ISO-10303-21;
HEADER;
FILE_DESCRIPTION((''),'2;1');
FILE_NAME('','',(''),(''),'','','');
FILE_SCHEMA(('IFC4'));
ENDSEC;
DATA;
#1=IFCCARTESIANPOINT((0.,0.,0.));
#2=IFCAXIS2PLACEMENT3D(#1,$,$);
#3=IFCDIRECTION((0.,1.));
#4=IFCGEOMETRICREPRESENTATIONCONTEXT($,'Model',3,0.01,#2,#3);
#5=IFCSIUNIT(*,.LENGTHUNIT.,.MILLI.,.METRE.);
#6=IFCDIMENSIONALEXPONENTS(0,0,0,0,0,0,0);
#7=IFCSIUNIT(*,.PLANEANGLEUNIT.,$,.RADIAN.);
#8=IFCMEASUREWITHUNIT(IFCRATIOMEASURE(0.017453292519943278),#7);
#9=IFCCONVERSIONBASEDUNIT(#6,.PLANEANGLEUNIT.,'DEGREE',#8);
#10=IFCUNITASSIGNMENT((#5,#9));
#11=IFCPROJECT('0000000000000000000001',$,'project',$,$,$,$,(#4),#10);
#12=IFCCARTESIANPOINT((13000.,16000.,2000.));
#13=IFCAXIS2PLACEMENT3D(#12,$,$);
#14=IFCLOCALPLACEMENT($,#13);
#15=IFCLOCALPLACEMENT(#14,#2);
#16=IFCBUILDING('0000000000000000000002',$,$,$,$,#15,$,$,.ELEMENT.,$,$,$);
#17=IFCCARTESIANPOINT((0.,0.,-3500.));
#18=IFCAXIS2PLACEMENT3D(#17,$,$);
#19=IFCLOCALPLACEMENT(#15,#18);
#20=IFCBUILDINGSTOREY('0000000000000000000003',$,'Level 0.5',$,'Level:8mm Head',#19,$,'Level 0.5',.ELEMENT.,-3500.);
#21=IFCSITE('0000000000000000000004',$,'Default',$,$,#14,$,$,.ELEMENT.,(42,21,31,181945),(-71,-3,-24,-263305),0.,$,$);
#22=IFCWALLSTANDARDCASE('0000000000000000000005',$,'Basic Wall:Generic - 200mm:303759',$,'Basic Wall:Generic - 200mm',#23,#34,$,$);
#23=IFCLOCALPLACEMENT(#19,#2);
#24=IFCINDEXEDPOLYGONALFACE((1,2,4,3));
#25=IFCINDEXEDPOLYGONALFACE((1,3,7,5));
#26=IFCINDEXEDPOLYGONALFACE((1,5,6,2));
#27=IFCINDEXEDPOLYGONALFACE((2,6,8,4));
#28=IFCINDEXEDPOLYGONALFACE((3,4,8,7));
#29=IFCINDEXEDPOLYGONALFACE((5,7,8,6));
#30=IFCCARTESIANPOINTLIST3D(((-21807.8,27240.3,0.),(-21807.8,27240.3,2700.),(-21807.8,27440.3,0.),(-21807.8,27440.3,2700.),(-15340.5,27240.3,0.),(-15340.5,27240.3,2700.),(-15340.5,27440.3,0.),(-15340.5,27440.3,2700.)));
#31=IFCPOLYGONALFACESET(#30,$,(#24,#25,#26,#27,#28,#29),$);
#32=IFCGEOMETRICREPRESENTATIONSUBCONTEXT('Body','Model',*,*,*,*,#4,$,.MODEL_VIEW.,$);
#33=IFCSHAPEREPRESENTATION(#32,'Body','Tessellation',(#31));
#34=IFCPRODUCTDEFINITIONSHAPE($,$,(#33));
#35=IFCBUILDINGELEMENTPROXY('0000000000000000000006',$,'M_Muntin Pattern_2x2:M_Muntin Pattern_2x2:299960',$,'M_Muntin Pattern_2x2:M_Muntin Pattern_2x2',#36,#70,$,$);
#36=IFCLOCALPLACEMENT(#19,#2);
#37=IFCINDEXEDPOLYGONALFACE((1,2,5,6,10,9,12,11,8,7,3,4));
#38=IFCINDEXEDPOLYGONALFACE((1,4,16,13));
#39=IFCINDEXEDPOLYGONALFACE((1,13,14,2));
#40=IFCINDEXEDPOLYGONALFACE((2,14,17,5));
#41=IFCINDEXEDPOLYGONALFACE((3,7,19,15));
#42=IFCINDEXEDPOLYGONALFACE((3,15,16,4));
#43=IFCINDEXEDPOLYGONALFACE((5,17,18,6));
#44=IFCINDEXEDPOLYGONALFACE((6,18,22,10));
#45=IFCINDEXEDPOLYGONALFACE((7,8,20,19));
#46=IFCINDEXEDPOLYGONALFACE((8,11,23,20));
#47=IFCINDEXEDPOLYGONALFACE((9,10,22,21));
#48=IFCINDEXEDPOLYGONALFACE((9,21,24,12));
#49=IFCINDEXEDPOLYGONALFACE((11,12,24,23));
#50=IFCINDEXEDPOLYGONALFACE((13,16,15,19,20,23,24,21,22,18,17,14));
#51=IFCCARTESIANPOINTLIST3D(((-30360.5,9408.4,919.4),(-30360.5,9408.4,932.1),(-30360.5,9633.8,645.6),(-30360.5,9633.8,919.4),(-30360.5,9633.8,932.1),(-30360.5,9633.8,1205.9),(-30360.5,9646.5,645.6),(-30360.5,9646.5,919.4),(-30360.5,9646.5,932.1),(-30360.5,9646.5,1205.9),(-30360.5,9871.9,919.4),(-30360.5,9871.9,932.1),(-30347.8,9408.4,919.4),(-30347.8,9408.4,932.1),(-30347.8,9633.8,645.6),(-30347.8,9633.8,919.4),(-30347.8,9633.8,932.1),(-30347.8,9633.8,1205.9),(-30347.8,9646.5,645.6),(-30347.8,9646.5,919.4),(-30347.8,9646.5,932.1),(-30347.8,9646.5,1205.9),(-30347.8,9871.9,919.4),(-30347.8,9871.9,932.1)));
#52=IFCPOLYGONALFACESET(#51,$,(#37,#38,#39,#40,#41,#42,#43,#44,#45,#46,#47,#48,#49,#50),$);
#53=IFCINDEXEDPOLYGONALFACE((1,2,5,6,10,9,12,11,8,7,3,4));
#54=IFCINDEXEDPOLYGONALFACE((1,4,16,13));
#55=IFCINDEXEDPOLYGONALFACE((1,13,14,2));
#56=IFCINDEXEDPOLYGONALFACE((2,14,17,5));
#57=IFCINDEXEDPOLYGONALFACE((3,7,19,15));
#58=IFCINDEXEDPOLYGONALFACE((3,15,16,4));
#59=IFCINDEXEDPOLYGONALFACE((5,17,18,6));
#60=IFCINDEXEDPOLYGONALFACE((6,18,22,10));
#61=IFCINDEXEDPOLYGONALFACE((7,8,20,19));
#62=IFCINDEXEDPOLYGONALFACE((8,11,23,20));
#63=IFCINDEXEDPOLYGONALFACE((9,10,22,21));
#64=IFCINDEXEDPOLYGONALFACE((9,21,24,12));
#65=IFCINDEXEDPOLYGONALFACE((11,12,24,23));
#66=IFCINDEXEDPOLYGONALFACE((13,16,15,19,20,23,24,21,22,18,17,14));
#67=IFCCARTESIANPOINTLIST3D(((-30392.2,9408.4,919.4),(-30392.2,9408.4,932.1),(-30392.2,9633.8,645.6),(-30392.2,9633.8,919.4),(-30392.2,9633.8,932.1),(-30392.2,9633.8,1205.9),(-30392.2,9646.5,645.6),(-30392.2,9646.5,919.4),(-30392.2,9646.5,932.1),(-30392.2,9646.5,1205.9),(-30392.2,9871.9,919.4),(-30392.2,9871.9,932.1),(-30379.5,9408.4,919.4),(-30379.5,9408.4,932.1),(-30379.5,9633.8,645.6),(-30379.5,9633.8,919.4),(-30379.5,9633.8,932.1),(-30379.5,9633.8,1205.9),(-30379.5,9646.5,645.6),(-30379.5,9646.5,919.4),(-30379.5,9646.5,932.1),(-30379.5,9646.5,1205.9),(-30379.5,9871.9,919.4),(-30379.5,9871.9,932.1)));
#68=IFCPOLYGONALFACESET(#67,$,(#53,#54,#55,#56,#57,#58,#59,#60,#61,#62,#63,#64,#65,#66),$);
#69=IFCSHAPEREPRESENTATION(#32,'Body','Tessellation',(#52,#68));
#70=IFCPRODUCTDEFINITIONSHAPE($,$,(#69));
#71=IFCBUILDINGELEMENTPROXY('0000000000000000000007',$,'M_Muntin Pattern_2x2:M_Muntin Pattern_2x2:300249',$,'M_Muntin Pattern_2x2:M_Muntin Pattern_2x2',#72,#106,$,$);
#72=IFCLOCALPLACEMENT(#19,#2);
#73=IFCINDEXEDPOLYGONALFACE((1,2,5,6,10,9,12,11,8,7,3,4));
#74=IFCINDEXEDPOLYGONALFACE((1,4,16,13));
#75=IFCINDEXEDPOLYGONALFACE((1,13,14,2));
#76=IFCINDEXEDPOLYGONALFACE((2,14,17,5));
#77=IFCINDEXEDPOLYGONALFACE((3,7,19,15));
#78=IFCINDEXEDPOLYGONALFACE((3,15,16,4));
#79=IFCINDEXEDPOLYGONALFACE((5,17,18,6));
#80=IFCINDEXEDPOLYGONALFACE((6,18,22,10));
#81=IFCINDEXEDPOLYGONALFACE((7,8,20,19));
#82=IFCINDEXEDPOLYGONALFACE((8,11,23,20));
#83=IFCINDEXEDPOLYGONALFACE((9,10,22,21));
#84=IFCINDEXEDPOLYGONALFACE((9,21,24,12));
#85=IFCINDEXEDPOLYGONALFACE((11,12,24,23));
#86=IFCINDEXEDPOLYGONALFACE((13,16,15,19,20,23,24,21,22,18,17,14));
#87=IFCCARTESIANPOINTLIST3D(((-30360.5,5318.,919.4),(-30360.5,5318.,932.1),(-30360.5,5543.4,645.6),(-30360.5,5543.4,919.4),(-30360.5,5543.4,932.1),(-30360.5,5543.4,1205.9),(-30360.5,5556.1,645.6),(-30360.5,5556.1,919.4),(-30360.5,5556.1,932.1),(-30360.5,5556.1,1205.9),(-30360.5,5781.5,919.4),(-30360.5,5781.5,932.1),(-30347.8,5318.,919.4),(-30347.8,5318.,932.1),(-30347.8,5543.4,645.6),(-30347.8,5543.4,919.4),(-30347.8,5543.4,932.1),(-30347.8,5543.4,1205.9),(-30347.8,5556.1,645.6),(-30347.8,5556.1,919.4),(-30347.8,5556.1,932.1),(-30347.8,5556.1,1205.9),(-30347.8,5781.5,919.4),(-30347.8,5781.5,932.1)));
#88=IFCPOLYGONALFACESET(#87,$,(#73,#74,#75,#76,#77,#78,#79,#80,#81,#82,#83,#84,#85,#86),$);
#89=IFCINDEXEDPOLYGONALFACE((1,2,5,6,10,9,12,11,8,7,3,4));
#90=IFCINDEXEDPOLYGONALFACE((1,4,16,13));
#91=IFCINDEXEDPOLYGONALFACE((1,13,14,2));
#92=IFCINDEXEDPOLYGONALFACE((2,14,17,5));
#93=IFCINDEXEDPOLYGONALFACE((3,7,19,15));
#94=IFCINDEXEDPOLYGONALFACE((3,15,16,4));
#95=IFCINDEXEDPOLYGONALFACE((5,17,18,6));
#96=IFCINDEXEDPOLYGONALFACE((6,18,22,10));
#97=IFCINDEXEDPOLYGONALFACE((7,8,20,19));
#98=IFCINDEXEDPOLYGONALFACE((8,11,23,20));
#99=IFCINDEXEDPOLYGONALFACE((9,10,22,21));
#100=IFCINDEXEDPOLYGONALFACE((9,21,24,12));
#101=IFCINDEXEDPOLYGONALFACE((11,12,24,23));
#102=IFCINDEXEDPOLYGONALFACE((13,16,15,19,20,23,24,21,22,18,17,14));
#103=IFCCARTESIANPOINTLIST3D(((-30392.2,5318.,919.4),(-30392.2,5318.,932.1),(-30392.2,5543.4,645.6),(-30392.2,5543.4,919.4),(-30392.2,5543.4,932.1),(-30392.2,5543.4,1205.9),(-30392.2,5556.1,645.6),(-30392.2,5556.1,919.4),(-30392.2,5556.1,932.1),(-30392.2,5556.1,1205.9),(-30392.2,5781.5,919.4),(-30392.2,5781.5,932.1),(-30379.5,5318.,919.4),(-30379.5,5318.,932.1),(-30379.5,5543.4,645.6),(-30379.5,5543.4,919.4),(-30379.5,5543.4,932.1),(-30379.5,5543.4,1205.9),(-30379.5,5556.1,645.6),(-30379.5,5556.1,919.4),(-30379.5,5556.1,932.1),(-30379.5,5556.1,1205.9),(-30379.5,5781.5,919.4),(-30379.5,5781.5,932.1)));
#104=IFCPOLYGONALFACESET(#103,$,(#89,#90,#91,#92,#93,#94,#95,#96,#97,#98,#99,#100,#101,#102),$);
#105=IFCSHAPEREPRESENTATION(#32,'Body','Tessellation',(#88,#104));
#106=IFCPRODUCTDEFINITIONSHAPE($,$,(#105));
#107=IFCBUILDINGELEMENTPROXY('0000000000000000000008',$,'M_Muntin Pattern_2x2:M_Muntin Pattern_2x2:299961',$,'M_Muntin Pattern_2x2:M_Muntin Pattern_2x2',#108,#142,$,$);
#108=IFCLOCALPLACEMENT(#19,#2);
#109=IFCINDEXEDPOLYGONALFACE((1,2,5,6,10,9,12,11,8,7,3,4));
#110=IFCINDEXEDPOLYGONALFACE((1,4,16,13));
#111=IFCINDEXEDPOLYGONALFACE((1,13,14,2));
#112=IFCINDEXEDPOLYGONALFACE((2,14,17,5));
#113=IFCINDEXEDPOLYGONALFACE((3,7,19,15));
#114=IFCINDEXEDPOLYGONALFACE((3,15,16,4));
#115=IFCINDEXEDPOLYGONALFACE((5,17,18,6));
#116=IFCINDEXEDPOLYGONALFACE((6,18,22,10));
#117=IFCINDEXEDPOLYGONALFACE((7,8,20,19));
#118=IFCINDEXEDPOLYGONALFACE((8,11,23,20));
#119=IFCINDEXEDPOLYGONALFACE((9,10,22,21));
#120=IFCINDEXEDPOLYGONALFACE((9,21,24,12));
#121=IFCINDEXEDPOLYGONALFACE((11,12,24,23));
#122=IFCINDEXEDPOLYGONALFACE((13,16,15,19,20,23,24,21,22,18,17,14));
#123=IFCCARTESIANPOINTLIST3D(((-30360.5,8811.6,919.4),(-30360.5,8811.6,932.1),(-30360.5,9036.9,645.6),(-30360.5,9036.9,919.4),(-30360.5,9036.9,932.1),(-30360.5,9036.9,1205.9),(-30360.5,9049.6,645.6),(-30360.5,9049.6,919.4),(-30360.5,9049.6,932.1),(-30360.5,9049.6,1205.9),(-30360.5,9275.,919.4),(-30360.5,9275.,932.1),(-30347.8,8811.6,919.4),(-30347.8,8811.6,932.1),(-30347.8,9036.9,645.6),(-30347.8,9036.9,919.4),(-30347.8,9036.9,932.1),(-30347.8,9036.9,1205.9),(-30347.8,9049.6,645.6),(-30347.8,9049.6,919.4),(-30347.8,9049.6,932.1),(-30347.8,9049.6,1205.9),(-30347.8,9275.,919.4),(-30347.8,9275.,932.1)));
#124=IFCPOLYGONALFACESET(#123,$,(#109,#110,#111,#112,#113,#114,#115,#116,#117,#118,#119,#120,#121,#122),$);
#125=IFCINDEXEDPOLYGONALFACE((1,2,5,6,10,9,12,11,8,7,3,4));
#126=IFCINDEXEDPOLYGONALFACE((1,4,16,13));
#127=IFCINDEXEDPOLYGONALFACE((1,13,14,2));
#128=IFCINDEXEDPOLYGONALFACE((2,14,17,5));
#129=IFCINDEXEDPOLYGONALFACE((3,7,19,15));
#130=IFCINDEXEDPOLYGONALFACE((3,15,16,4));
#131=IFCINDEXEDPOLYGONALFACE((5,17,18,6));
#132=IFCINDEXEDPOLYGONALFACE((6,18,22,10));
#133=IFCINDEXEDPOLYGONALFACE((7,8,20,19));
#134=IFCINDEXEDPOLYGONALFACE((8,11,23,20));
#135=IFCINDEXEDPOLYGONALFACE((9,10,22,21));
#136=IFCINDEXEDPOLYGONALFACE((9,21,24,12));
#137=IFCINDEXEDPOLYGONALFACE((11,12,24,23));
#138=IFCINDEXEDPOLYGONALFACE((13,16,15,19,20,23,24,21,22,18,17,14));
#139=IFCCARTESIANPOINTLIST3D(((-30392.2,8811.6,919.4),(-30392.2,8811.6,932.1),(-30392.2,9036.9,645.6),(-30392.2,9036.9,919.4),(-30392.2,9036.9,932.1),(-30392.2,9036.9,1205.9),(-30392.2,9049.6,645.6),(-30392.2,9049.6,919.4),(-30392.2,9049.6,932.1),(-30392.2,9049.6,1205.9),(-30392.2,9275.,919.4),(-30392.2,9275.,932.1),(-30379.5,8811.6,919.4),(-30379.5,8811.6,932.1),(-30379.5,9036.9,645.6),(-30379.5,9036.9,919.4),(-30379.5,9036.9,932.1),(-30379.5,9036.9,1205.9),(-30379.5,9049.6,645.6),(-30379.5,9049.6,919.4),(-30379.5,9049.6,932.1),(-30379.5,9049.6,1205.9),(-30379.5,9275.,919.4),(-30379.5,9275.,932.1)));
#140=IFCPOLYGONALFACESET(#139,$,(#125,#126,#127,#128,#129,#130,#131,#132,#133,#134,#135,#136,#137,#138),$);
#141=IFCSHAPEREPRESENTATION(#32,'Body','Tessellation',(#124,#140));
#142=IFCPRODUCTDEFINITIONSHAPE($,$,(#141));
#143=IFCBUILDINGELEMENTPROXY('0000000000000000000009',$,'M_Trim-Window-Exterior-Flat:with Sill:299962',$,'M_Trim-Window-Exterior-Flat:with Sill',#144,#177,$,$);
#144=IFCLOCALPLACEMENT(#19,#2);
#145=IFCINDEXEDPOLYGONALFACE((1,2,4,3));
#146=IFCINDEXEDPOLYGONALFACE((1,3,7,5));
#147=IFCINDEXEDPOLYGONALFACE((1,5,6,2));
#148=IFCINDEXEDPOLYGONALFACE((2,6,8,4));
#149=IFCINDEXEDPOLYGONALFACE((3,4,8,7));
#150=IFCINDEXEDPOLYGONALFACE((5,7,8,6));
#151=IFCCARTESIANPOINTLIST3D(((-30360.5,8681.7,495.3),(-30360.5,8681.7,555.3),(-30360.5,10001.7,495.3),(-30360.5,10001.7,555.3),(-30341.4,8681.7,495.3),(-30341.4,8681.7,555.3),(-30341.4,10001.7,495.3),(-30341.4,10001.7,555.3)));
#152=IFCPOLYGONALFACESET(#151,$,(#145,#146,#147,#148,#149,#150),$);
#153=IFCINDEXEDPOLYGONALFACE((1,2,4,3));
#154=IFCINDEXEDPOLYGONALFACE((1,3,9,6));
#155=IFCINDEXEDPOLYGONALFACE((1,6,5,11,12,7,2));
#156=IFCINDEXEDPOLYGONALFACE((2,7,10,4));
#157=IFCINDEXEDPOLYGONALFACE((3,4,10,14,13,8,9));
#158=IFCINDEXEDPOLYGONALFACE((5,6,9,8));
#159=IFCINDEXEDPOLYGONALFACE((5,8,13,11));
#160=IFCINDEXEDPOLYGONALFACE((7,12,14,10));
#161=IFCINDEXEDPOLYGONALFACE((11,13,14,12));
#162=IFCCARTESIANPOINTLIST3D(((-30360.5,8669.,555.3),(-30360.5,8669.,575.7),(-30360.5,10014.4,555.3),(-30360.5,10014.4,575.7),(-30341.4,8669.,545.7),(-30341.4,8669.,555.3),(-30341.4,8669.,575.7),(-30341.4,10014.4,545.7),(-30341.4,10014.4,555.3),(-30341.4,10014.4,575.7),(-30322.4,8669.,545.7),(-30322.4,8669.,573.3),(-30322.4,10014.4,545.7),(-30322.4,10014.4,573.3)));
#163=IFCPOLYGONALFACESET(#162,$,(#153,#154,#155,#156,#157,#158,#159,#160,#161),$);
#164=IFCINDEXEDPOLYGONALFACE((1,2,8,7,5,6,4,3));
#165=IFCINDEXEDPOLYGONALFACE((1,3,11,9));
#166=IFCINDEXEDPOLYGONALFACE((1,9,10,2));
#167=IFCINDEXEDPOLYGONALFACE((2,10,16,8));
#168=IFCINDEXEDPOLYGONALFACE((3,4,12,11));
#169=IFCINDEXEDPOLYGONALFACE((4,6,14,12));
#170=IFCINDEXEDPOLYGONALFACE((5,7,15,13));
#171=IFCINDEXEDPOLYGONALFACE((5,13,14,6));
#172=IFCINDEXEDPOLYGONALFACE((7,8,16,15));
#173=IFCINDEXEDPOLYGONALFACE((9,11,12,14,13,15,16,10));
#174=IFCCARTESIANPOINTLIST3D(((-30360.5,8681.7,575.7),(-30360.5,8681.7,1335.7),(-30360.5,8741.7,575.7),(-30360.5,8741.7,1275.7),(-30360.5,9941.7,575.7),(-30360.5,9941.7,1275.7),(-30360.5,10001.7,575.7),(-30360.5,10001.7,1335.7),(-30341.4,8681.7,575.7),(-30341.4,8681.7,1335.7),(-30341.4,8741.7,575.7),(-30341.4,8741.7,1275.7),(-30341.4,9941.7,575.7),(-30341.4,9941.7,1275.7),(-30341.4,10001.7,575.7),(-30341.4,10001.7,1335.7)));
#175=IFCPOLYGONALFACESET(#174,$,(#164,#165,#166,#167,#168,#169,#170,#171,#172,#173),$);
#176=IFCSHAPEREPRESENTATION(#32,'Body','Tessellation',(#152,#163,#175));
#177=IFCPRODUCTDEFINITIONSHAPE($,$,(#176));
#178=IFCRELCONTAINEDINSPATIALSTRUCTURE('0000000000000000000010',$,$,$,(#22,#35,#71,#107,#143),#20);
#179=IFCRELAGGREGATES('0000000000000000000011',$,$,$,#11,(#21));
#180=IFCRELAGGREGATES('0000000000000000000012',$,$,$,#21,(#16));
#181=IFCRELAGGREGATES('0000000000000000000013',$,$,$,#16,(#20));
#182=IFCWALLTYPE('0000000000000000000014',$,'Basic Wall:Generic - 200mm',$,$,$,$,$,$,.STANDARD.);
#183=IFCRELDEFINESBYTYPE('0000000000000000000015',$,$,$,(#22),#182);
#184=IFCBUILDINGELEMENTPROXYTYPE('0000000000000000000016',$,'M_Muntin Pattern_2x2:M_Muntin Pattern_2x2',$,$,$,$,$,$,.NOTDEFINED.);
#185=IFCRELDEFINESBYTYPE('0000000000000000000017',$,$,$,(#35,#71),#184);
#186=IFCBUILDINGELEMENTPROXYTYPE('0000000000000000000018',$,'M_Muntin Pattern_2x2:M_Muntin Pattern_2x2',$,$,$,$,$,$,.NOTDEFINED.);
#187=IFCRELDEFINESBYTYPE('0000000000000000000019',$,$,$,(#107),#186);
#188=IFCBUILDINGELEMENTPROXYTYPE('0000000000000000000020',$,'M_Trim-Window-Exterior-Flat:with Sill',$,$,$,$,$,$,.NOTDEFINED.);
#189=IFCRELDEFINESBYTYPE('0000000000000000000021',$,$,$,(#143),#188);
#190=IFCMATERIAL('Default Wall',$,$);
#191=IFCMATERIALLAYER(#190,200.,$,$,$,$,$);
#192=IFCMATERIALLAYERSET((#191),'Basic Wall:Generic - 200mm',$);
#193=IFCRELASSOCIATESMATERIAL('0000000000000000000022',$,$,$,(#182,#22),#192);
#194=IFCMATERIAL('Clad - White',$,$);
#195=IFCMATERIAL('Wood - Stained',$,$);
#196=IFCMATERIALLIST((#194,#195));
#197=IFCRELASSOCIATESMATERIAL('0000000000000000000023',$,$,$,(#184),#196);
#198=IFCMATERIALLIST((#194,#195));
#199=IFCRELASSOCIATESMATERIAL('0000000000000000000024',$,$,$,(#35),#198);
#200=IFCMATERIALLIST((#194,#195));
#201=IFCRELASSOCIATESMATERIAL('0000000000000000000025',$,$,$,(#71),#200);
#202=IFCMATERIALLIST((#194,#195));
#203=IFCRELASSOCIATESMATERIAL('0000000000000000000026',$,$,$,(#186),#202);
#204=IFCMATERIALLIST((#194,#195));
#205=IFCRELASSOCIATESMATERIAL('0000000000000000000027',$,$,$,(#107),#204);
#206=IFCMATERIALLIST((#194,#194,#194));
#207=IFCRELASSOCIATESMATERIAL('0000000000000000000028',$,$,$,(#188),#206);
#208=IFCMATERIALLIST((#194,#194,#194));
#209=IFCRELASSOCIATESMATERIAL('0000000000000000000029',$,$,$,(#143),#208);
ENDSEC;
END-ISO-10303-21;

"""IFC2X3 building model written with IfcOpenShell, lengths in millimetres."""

from ifc_helpers import new_model, entity, si_unit, converted_unit, direction, frame, frame_2d, origin, place, context, subcontext, project, spatial, polyline, rectangle, outline, extrude, source, transform, mapped, material, material_list, layer, layer_set, layer_usage, type_object, type_shapes, element, save


model = new_model("IFC2X3")

# Units and contexts
model_context = context("Model", 3, precision=0.01, world=origin(), true_north=direction((0.0, 1.0)))
body_context = subcontext(model_context, "Body", "Model", "MODEL_VIEW")
ifc_project = project(units=[si_unit("LENGTHUNIT", "METRE", prefix="MILLI"), converted_unit("PLANEANGLEUNIT", "DEGREE", entity("IfcRatioMeasure", 0.017453292519943278), si_unit("PLANEANGLEUNIT", "RADIAN"), dimensions=[0, 0, 0, 0, 0, 0, 0])], contexts=[model_context])

# Site, building, storey
site_placement = place(None, frame((13000.0, 16000.0, 2000.0)))
site = spatial("IfcSite", under=ifc_project, at=site_placement, Name="Default", CompositionType="ELEMENT", RefLatitude=(42, 21, 31, 181945), RefLongitude=(-71, -3, -24, -263305), RefElevation=0.0)
building_placement = place(site_placement, origin())
building = spatial("IfcBuilding", under=site, at=building_placement, CompositionType="ELEMENT")
storey_placement = place(building_placement, frame((0.0, 0.0, -3500.0)))
storey = spatial("IfcBuildingStorey", under=building, at=storey_placement, Name="Level 0.5", ObjectType="Level:8mm Head", LongName="Level 0.5", CompositionType="ELEMENT", Elevation=-3500.0)

# Shared definitions
ifc_material_1 = material(Name="Default Wall")
ifc_layer_1 = layer(ifc_material_1, 200.0)
ifc_layer_set_1 = layer_set([ifc_layer_1], Name="Basic Wall:Generic - 200mm")
wall_type_1 = type_object("IfcWallType", Name="Basic Wall:Generic - 200mm", PredefinedType="STANDARD", material=ifc_layer_set_1)

# Wall
ifc_layer_usage_1 = layer_usage(ifc_layer_set_1, "AXIS2", "NEGATIVE", 100.0)
wall_1_placement = place(storey_placement, frame((-15340.5, 27340.3, 0.0), z_axis=(0.0, 0.0, 1.0), x_axis=(-1.0, 0.0, 0.0)))
element("IfcWallStandardCase", 1, at=wall_1_placement, inside=storey, type_object=wall_type_1, material=ifc_layer_usage_1, Name="Basic Wall:Generic - 200mm:303759", ObjectType="Basic Wall:Generic - 200mm", context=body_context, shape_type="SweptSolid", body=[
    extrude(rectangle(XDim=6467.3, YDim=200.0, at=frame_2d((3233.6, 0.0), x_axis=(-1.0, 0.0))), origin(), (0.0, 0.0, 1.0), 2700.0),
])

# Building element proxies
ifc_material_2 = material(Name="Clad - White")
ifc_material_3 = material(Name="Wood - Stained")
ifc_material_list_1 = material_list([ifc_material_2, ifc_material_3])
ifc_material_list_2 = material_list([ifc_material_2, ifc_material_3])
building_element_proxy_type_1 = type_object("IfcBuildingElementProxyType", Name="M_Muntin Pattern_2x2:M_Muntin Pattern_2x2", PredefinedType="NOTDEFINED", material=ifc_material_list_2)
shared_shape_1 = source(origin(), body_context, "Body", "SweptSolid", [
    extrude(outline(polyline([(6.4, -6.4), (280.1, -6.4), (280.1, 6.3), (6.4, 6.3), (6.4, 231.7), (-6.3, 231.7), (-6.3, 6.3), (-280.2, 6.3), (-280.2, -6.4), (-6.3, -6.4), (-6.3, -231.7), (6.4, -231.7), (6.4, -6.4)])), frame((0.0, 9.5, 280.1), z_axis=(0.0, 1.0, 0.0), x_axis=(0.0, 0.0, 1.0)), (0.0, 0.0, 1.0), 12.7),
    extrude(outline(polyline([(6.4, -6.4), (280.2, -6.4), (280.2, 6.3), (6.4, 6.3), (6.4, 231.7), (-6.3, 231.7), (-6.3, 6.3), (-280.2, 6.3), (-280.2, -6.4), (-6.3, -6.4), (-6.3, -231.7), (6.4, -231.7), (6.4, -6.4)])), frame((0.0, -22.2, 280.2), z_axis=(0.0, 1.0, 0.0), x_axis=(0.0, 0.0, 1.0)), (0.0, 0.0, 1.0), 12.7),
])
type_shapes(building_element_proxy_type_1, [shared_shape_1])
proxy_1_placement = place(storey_placement, frame((-30370.0, 9640.1, 645.6), z_axis=(0.0, 0.0, 1.0), x_axis=(0.0, -1.0, 0.0)))
element("IfcBuildingElementProxy", 2, at=proxy_1_placement, inside=storey, type_object=building_element_proxy_type_1, material=ifc_material_list_1, Name="M_Muntin Pattern_2x2:M_Muntin Pattern_2x2:299960", ObjectType="M_Muntin Pattern_2x2:M_Muntin Pattern_2x2", context=body_context, shape_type="MappedRepresentation", body=[
    mapped(shared_shape_1, transform((0.0, 0.0, 0.0), scale=1.0)),
])
ifc_material_list_3 = material_list([ifc_material_2, ifc_material_3])
proxy_2_placement = place(storey_placement, frame((-30370.0, 5549.7, 645.6), z_axis=(0.0, 0.0, 1.0), x_axis=(0.0, -1.0, 0.0)))
element("IfcBuildingElementProxy", 3, at=proxy_2_placement, inside=storey, type_object=building_element_proxy_type_1, material=ifc_material_list_3, Name="M_Muntin Pattern_2x2:M_Muntin Pattern_2x2:300249", ObjectType="M_Muntin Pattern_2x2:M_Muntin Pattern_2x2", context=body_context, shape_type="MappedRepresentation", body=[
    mapped(shared_shape_1, transform((0.0, 0.0, 0.0), scale=1.0)),
])
ifc_material_list_4 = material_list([ifc_material_2, ifc_material_3])
ifc_material_list_5 = material_list([ifc_material_2, ifc_material_3])
building_element_proxy_type_2 = type_object("IfcBuildingElementProxyType", Name="M_Muntin Pattern_2x2:M_Muntin Pattern_2x2", PredefinedType="NOTDEFINED", material=ifc_material_list_5)
shared_shape_2 = source(origin(), body_context, "Body", "SweptSolid", [
    extrude(outline(polyline([(6.4, -6.4), (280.1, -6.4), (280.1, 6.3), (6.4, 6.3), (6.4, 231.7), (-6.3, 231.7), (-6.3, 6.3), (-280.2, 6.3), (-280.2, -6.4), (-6.3, -6.4), (-6.3, -231.7), (6.4, -231.7), (6.4, -6.4)])), frame((0.0, -22.2, 280.1), z_axis=(0.0, 1.0, 0.0), x_axis=(0.0, 0.0, 1.0)), (0.0, 0.0, 1.0), 12.7),
    extrude(outline(polyline([(6.4, -6.4), (280.2, -6.4), (280.2, 6.3), (6.4, 6.3), (6.4, 231.7), (-6.3, 231.7), (-6.3, 6.3), (-280.2, 6.3), (-280.2, -6.4), (-6.3, -6.4), (-6.3, -231.7), (6.4, -231.7), (6.4, -6.4)])), frame((0.0, 9.5, 280.2), z_axis=(0.0, 1.0, 0.0), x_axis=(0.0, 0.0, 1.0)), (0.0, 0.0, 1.0), 12.7),
])
type_shapes(building_element_proxy_type_2, [shared_shape_2])
proxy_3_placement = place(storey_placement, frame((-30370.0, 9043.3, 645.6), z_axis=(0.0, 0.0, 1.0), x_axis=(0.0, 1.0, 0.0)))
element("IfcBuildingElementProxy", 4, at=proxy_3_placement, inside=storey, type_object=building_element_proxy_type_2, material=ifc_material_list_4, Name="M_Muntin Pattern_2x2:M_Muntin Pattern_2x2:299961", ObjectType="M_Muntin Pattern_2x2:M_Muntin Pattern_2x2", context=body_context, shape_type="MappedRepresentation", body=[
    mapped(shared_shape_2, transform((0.0, 0.0, 0.0), scale=1.0)),
])
ifc_material_list_6 = material_list([ifc_material_2, ifc_material_2, ifc_material_2])
ifc_material_list_7 = material_list([ifc_material_2, ifc_material_2, ifc_material_2])
building_element_proxy_type_3 = type_object("IfcBuildingElementProxyType", Name="M_Trim-Window-Exterior-Flat:with Sill", PredefinedType="NOTDEFINED", material=ifc_material_list_7)
shared_shape_3 = source(origin(), body_context, "Body", "SweptSolid", [
    extrude(rectangle(XDim=1320.0, YDim=60.0, at=frame_2d((0.0, 0.0), x_axis=(1.0, 0.0))), frame((0.0, -750.4, 0.0), z_axis=(0.0, 0.0, 1.0), x_axis=(-1.0, 0.0, 0.0)), (0.0, 0.0, 1.0), 19.0),
    extrude(outline(polyline([(-19.0, -15.2), (0.0, -15.2), (0.0, -5.7), (19.0, -5.7), (19.0, 14.8), (0.0, 14.8), (-19.0, 12.3), (-19.0, -15.2)])), frame((-672.7, -714.8, 19.0), z_axis=(1.0, 0.0, 0.0), x_axis=(0.0, 0.0, -1.0)), (0.0, 0.0, 1.0), 1345.4),
    extrude(outline(polyline([(-395.0, -660.0), (365.0, -660.0), (365.0, -600.0), (-335.0, -600.0), (-335.0, 600.0), (365.0, 600.0), (365.0, 660.0), (-395.0, 660.0), (-395.0, -660.0)])), frame((0.0, -335.0, 0.0), z_axis=(0.0, 0.0, 1.0), x_axis=(0.0, -1.0, 0.0)), (0.0, 0.0, 1.0), 19.0),
])
type_shapes(building_element_proxy_type_3, [shared_shape_3])
proxy_4_placement = place(storey_placement, frame((-30360.5, 9341.7, 1275.7), z_axis=(1.0, 0.0, 0.0), x_axis=(0.0, 1.0, 0.0)))
element("IfcBuildingElementProxy", 5, at=proxy_4_placement, inside=storey, type_object=building_element_proxy_type_3, material=ifc_material_list_6, Name="M_Trim-Window-Exterior-Flat:with Sill:299962", ObjectType="M_Trim-Window-Exterior-Flat:with Sill", context=body_context, shape_type="MappedRepresentation", body=[
    mapped(shared_shape_3, transform((0.0, 0.0, 0.0), scale=1.0)),
])

save(model, "model.ifc")
